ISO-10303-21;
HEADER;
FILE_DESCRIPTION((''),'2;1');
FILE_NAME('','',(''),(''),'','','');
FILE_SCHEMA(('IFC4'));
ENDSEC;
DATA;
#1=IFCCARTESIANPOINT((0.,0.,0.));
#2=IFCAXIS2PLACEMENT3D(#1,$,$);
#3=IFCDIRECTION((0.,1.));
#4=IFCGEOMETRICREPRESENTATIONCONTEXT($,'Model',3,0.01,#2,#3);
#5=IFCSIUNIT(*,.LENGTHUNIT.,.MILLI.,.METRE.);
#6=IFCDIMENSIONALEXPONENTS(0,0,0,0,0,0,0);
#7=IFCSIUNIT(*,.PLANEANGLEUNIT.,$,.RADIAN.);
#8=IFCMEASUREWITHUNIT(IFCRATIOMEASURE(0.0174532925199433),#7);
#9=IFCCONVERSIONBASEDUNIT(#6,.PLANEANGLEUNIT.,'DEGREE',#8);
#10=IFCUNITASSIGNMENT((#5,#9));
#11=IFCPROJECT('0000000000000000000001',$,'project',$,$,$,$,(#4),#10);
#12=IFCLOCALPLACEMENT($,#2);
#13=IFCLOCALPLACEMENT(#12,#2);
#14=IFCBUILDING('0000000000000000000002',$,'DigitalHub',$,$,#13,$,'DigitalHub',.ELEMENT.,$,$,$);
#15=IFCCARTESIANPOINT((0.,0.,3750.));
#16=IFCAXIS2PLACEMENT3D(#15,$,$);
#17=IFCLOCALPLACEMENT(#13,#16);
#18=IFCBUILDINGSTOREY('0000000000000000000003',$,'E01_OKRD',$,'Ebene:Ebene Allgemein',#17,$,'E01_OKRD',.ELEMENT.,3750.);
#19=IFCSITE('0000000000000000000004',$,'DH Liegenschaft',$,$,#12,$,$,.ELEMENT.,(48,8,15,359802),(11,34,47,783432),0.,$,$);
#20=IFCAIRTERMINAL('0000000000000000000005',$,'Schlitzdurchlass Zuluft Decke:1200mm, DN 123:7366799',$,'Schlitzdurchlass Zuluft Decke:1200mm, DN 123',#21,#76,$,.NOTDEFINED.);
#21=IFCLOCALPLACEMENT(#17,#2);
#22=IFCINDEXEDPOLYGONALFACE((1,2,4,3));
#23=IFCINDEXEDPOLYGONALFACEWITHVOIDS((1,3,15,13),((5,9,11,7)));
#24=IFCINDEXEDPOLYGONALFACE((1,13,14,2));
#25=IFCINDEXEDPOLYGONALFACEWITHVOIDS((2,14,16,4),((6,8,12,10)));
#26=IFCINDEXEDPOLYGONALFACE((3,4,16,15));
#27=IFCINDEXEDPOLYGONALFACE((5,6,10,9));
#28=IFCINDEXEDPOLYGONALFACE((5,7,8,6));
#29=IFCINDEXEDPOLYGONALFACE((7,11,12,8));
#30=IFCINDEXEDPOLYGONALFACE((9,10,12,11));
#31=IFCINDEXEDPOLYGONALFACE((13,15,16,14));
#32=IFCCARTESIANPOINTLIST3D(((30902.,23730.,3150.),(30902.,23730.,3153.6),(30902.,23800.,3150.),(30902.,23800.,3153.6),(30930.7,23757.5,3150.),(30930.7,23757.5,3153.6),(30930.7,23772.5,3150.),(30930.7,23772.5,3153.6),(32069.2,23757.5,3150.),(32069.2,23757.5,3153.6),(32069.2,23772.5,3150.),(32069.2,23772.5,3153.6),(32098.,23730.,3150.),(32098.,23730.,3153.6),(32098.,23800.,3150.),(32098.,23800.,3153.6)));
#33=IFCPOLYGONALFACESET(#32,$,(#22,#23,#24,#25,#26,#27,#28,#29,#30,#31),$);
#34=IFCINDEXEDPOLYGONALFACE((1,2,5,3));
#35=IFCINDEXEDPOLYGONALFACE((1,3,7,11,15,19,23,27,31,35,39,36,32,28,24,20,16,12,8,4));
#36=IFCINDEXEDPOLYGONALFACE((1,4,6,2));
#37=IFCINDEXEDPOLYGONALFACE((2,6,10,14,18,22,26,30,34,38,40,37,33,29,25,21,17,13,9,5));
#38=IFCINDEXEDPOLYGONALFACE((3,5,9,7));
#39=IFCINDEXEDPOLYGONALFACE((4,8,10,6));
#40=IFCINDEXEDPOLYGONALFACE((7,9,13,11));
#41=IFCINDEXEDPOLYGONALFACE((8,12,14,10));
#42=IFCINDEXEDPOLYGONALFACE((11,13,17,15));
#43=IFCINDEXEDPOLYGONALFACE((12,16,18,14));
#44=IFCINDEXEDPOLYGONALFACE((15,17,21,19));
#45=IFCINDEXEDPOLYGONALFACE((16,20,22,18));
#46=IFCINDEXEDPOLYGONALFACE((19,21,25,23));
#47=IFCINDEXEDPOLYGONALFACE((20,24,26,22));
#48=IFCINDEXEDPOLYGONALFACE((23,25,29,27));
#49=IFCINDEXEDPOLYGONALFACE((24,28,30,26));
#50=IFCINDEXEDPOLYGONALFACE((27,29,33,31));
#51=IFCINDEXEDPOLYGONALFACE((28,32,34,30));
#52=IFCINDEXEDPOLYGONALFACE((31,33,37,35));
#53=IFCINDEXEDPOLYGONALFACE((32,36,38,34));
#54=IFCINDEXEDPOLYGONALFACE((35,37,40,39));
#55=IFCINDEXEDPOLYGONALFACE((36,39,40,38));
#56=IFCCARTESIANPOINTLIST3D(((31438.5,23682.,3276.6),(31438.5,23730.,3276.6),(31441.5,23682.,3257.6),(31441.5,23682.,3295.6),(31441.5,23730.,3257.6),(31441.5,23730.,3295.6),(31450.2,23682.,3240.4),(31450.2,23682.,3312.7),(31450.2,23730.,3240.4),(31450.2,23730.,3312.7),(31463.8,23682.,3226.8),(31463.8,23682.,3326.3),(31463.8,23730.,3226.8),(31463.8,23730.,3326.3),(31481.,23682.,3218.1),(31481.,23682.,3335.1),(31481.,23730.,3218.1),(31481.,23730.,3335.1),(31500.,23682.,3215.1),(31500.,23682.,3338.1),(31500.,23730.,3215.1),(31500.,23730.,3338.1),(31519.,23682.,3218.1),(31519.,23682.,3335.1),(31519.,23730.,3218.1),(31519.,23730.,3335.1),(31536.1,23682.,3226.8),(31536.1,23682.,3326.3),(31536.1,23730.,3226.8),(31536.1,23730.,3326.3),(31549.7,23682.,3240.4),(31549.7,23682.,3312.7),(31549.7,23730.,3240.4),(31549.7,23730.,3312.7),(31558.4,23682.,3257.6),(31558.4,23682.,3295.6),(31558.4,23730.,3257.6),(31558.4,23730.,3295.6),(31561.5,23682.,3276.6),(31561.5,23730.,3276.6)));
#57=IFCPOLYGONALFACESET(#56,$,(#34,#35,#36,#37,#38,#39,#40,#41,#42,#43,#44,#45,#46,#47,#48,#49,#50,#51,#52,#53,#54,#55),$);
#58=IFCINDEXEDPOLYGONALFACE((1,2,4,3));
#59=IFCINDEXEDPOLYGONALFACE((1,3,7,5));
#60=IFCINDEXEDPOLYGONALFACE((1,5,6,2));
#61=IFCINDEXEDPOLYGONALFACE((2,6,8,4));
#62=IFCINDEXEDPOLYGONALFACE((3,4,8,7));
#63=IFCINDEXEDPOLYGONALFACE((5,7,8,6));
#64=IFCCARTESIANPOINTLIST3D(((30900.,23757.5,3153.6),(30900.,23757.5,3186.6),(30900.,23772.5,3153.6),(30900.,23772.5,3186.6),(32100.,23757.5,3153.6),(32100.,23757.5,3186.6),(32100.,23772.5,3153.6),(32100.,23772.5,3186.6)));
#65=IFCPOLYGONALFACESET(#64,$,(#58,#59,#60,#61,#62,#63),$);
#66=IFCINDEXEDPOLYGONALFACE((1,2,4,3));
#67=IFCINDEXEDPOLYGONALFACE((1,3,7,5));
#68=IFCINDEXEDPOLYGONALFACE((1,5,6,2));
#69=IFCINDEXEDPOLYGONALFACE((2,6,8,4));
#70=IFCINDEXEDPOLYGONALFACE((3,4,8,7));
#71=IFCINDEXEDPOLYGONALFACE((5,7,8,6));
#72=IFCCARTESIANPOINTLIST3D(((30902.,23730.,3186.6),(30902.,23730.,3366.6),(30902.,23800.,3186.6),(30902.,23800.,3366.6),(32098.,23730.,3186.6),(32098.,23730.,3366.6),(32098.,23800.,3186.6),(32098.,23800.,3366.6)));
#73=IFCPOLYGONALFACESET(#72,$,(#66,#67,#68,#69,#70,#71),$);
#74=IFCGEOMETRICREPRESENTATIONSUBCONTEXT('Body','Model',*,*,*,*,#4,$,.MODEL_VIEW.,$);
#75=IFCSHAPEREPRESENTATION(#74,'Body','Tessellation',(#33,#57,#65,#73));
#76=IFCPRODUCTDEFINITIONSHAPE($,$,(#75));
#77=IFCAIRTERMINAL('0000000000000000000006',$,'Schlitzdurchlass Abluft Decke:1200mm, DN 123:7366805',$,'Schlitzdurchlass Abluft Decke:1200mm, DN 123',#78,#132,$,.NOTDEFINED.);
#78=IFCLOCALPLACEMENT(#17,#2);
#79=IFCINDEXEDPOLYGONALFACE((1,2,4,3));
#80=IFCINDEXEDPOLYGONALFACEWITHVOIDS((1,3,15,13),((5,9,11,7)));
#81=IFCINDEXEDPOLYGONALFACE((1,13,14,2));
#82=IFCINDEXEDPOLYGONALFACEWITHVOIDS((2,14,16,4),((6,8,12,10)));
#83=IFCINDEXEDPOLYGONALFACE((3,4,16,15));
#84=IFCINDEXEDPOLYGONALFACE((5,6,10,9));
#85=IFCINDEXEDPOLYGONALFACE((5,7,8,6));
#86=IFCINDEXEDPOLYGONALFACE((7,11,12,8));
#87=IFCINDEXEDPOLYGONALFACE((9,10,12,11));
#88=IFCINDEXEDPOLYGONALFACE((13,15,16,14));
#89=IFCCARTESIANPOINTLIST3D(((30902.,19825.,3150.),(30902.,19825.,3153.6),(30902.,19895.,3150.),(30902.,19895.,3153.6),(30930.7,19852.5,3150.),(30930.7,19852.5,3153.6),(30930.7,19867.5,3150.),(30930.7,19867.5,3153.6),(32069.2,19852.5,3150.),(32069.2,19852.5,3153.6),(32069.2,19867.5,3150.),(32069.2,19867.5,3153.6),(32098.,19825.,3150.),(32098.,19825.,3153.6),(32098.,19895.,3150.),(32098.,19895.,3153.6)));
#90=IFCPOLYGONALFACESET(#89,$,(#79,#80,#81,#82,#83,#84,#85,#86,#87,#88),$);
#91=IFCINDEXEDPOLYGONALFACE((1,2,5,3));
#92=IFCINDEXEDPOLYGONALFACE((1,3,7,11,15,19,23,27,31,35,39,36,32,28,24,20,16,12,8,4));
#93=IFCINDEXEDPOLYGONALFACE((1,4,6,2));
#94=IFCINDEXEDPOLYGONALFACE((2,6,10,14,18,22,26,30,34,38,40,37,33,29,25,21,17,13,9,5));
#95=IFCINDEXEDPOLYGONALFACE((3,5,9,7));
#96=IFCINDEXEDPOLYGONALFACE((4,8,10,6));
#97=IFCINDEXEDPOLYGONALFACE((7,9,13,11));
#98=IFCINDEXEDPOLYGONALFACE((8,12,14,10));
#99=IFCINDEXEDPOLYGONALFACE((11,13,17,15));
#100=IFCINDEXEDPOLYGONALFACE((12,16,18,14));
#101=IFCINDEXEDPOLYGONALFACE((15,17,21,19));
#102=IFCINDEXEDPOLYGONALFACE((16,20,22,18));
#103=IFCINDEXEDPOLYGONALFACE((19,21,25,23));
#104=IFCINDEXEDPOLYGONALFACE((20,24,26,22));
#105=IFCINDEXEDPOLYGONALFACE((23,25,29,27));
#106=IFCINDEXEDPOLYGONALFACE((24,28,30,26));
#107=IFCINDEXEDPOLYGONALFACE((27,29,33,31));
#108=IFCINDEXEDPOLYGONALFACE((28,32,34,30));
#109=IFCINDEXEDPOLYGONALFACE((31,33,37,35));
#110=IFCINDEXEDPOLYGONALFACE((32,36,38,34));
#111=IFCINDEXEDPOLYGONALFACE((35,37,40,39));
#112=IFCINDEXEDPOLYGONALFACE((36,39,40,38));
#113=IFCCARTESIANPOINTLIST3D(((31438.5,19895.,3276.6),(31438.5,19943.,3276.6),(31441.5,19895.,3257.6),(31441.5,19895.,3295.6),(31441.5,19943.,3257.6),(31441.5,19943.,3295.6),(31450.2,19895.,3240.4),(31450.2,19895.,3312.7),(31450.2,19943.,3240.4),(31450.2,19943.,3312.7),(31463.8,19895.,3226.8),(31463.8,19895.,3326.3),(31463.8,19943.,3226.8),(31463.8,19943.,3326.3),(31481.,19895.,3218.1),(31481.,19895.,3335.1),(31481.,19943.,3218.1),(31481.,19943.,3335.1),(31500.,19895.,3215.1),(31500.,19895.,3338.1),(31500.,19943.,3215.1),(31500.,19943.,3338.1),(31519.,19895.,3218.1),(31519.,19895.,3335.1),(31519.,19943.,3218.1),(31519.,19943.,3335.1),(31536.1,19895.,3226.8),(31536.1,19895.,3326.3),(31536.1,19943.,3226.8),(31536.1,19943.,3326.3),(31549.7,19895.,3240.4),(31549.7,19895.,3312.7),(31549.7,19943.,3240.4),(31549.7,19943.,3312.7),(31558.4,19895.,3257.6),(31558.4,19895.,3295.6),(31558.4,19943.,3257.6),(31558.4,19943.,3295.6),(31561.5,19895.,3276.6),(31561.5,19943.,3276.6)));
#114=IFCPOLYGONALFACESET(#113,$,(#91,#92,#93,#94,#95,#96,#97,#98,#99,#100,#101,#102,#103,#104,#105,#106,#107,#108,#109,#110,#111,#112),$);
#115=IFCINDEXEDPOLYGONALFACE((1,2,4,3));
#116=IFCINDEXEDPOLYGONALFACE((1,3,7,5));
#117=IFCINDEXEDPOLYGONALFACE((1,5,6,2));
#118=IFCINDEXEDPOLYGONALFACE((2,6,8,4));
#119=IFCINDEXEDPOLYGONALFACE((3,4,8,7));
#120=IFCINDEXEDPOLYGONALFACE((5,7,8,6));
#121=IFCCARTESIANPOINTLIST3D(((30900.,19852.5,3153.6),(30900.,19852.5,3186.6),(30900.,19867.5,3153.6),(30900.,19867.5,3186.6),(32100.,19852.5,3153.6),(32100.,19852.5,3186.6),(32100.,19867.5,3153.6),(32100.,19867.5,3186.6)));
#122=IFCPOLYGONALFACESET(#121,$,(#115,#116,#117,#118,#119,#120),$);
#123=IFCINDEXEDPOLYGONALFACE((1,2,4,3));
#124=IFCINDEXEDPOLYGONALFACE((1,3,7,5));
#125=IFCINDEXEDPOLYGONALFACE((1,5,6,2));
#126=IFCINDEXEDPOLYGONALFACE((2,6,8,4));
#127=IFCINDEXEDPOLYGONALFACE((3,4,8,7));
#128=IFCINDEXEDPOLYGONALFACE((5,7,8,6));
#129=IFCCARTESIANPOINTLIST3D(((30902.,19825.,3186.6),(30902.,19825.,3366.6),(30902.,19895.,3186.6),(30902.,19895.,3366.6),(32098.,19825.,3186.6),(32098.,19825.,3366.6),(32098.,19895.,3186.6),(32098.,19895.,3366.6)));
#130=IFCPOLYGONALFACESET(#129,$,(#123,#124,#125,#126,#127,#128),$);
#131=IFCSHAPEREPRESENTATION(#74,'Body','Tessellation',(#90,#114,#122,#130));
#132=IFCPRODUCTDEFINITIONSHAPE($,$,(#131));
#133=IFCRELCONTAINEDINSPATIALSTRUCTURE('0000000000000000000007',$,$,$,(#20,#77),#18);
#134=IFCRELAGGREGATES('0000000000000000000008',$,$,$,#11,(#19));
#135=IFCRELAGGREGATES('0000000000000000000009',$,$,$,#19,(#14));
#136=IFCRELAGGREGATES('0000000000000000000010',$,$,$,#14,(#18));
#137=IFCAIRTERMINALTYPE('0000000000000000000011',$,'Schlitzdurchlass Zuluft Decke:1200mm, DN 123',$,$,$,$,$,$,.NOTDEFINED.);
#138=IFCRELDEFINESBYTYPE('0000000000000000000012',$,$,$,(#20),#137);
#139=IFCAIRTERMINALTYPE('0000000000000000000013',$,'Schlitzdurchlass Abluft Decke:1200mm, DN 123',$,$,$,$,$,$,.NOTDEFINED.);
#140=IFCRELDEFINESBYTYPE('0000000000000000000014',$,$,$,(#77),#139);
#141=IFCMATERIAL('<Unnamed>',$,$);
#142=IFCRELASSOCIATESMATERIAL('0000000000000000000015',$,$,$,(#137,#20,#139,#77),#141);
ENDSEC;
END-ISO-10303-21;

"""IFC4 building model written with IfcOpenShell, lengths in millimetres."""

from ifc_helpers import new_model, entity, si_unit, converted_unit, direction, frame, origin, place, context, subcontext, project, spatial, indexed_curve, outline, extrude, source, transform, mapped, material, type_object, type_shapes, element, save


model = new_model("IFC4")

# Units and contexts
model_context = context("Model", 3, precision=0.01, world=origin(), true_north=direction((0.0, 1.0)))
body_context = subcontext(model_context, "Body", "Model", "MODEL_VIEW")
ifc_project = project(units=[si_unit("LENGTHUNIT", "METRE", prefix="MILLI"), converted_unit("PLANEANGLEUNIT", "DEGREE", entity("IfcRatioMeasure", 0.0174532925199433), si_unit("PLANEANGLEUNIT", "RADIAN"), dimensions=[0, 0, 0, 0, 0, 0, 0])], contexts=[model_context])

# Site, building, storey
site_placement = place(None, origin())
site = spatial("IfcSite", under=ifc_project, at=site_placement, Name="DH Liegenschaft", CompositionType="ELEMENT", RefLatitude=(48, 8, 15, 359802), RefLongitude=(11, 34, 47, 783432), RefElevation=0.0)
building_placement = place(site_placement, origin())
building = spatial("IfcBuilding", under=site, at=building_placement, Name="DigitalHub", LongName="DigitalHub", CompositionType="ELEMENT")
storey_placement = place(building_placement, frame((0.0, 0.0, 3750.0)))
storey = spatial("IfcBuildingStorey", under=building, at=storey_placement, Name="E01_OKRD", ObjectType="Ebene:Ebene Allgemein", LongName="E01_OKRD", CompositionType="ELEMENT", Elevation=3750.0)

# Shared definitions
ifc_material_1 = material(Name="<Unnamed>")

# Air terminals
air_terminal_type_1 = type_object("IfcAirTerminalType", Name="Schlitzdurchlass Zuluft Decke:1200mm, DN 123", PredefinedType="NOTDEFINED", material=ifc_material_1)
shared_shape_1 = source(origin(), body_context, "Body", "SweptSolid", [
    extrude(outline(indexed_curve([(-598.0, -35.0), (598.0, -35.0), (598.0, 35.0), (-598.0, 35.0), (-598.0, -35.0)], self_intersect=False), holes=[indexed_curve([(-569.2, -7.5), (-569.2, 7.5), (569.2, 7.5), (569.2, -7.5), (-569.2, -7.5)], self_intersect=False)]), frame((600.0, 35.0, 0.0), z_axis=(0.0, 0.0, 1.0), x_axis=(-1.0, 0.0, 0.0)), (0.0, 0.0, 1.0), 3.6),
    extrude(outline(indexed_curve([(61.5, 0.0), (58.5, 19.0), (49.8, 36.1), (36.1, 49.8), (19.0, 58.5), (0.0, 61.5), (-19.0, 58.5), (-36.1, 49.8), (-49.8, 36.1), (-58.5, 19.0), (-61.5, 0.0), (-58.5, -19.0), (-49.8, -36.1), (-36.1, -49.8), (-19.0, -58.5), (0.0, -61.5), (19.0, -58.5), (36.1, -49.8), (49.8, -36.1), (58.5, -19.0), (61.5, 0.0)], self_intersect=False)), frame((600.0, 70.0, 126.6), z_axis=(0.0, 1.0, 0.0), x_axis=(-1.0, 0.0, 0.0)), (0.0, 0.0, 1.0), 48.0),
    extrude(outline(indexed_curve([(-600.0, -7.5), (600.0, -7.5), (600.0, 7.5), (-600.0, 7.5), (-600.0, -7.5)], self_intersect=False)), frame((600.0, 35.0, 3.6), z_axis=(0.0, 0.0, 1.0), x_axis=(-1.0, 0.0, 0.0)), (0.0, 0.0, 1.0), 33.0),
    extrude(outline(indexed_curve([(-598.0, -35.0), (598.0, -35.0), (598.0, 35.0), (-598.0, 35.0), (-598.0, -35.0)], self_intersect=False)), frame((600.0, 35.0, 36.6), z_axis=(0.0, 0.0, 1.0), x_axis=(-1.0, 0.0, 0.0)), (0.0, 0.0, 1.0), 180.0),
])
type_shapes(air_terminal_type_1, [shared_shape_1])
air_terminal_1_placement = place(storey_placement, frame((32100.0, 23800.0, 3150.0), z_axis=(0.0, 0.0, 1.0), x_axis=(-1.0, 0.0, 0.0)))
element("IfcAirTerminal", 1, at=air_terminal_1_placement, inside=storey, type_object=air_terminal_type_1, material=ifc_material_1, Name="Schlitzdurchlass Zuluft Decke:1200mm, DN 123:7366799", ObjectType="Schlitzdurchlass Zuluft Decke:1200mm, DN 123", PredefinedType="NOTDEFINED", context=body_context, shape_type="MappedRepresentation", body=[
    mapped(shared_shape_1, transform((0.0, 0.0, 0.0), scale=1.0)),
])
air_terminal_type_2 = type_object("IfcAirTerminalType", Name="Schlitzdurchlass Abluft Decke:1200mm, DN 123", PredefinedType="NOTDEFINED", material=ifc_material_1)
shared_shape_2 = source(origin(), body_context, "Body", "SweptSolid", [
    extrude(outline(indexed_curve([(-598.0, -35.0), (598.0, -35.0), (598.0, 35.0), (-598.0, 35.0), (-598.0, -35.0)], self_intersect=False), holes=[indexed_curve([(-569.2, -7.5), (-569.2, 7.5), (569.2, 7.5), (569.2, -7.5), (-569.2, -7.5)], self_intersect=False)]), frame((0.0, 0.0, 0.0), z_axis=(0.0, 0.0, 1.0), x_axis=(-1.0, 0.0, 0.0)), (0.0, 0.0, 1.0), 3.6),
    extrude(outline(indexed_curve([(61.5, 0.0), (58.5, 19.0), (49.8, 36.1), (36.1, 49.8), (19.0, 58.5), (0.0, 61.5), (-19.0, 58.5), (-36.1, 49.8), (-49.8, 36.1), (-58.5, 19.0), (-61.5, 0.0), (-58.5, -19.0), (-49.8, -36.1), (-36.1, -49.8), (-19.0, -58.5), (0.0, -61.5), (19.0, -58.5), (36.1, -49.8), (49.8, -36.1), (58.5, -19.0), (61.5, 0.0)], self_intersect=False)), frame((0.0, 35.0, 126.6), z_axis=(0.0, 1.0, 0.0), x_axis=(-1.0, 0.0, 0.0)), (0.0, 0.0, 1.0), 48.0),
    extrude(outline(indexed_curve([(-600.0, -7.5), (600.0, -7.5), (600.0, 7.5), (-600.0, 7.5), (-600.0, -7.5)], self_intersect=False)), frame((0.0, 0.0, 3.6), z_axis=(0.0, 0.0, 1.0), x_axis=(-1.0, 0.0, 0.0)), (0.0, 0.0, 1.0), 33.0),
    extrude(outline(indexed_curve([(-598.0, -35.0), (598.0, -35.0), (598.0, 35.0), (-598.0, 35.0), (-598.0, -35.0)], self_intersect=False)), frame((0.0, 0.0, 36.6), z_axis=(0.0, 0.0, 1.0), x_axis=(-1.0, 0.0, 0.0)), (0.0, 0.0, 1.0), 180.0),
])
type_shapes(air_terminal_type_2, [shared_shape_2])
air_terminal_2_placement = place(storey_placement, frame((31500.0, 19860.0, 3150.0)))
element("IfcAirTerminal", 2, at=air_terminal_2_placement, inside=storey, type_object=air_terminal_type_2, material=ifc_material_1, Name="Schlitzdurchlass Abluft Decke:1200mm, DN 123:7366805", ObjectType="Schlitzdurchlass Abluft Decke:1200mm, DN 123", PredefinedType="NOTDEFINED", context=body_context, shape_type="MappedRepresentation", body=[
    mapped(shared_shape_2, transform((0.0, 0.0, 0.0), scale=1.0)),
])

save(model, "model.ifc")
